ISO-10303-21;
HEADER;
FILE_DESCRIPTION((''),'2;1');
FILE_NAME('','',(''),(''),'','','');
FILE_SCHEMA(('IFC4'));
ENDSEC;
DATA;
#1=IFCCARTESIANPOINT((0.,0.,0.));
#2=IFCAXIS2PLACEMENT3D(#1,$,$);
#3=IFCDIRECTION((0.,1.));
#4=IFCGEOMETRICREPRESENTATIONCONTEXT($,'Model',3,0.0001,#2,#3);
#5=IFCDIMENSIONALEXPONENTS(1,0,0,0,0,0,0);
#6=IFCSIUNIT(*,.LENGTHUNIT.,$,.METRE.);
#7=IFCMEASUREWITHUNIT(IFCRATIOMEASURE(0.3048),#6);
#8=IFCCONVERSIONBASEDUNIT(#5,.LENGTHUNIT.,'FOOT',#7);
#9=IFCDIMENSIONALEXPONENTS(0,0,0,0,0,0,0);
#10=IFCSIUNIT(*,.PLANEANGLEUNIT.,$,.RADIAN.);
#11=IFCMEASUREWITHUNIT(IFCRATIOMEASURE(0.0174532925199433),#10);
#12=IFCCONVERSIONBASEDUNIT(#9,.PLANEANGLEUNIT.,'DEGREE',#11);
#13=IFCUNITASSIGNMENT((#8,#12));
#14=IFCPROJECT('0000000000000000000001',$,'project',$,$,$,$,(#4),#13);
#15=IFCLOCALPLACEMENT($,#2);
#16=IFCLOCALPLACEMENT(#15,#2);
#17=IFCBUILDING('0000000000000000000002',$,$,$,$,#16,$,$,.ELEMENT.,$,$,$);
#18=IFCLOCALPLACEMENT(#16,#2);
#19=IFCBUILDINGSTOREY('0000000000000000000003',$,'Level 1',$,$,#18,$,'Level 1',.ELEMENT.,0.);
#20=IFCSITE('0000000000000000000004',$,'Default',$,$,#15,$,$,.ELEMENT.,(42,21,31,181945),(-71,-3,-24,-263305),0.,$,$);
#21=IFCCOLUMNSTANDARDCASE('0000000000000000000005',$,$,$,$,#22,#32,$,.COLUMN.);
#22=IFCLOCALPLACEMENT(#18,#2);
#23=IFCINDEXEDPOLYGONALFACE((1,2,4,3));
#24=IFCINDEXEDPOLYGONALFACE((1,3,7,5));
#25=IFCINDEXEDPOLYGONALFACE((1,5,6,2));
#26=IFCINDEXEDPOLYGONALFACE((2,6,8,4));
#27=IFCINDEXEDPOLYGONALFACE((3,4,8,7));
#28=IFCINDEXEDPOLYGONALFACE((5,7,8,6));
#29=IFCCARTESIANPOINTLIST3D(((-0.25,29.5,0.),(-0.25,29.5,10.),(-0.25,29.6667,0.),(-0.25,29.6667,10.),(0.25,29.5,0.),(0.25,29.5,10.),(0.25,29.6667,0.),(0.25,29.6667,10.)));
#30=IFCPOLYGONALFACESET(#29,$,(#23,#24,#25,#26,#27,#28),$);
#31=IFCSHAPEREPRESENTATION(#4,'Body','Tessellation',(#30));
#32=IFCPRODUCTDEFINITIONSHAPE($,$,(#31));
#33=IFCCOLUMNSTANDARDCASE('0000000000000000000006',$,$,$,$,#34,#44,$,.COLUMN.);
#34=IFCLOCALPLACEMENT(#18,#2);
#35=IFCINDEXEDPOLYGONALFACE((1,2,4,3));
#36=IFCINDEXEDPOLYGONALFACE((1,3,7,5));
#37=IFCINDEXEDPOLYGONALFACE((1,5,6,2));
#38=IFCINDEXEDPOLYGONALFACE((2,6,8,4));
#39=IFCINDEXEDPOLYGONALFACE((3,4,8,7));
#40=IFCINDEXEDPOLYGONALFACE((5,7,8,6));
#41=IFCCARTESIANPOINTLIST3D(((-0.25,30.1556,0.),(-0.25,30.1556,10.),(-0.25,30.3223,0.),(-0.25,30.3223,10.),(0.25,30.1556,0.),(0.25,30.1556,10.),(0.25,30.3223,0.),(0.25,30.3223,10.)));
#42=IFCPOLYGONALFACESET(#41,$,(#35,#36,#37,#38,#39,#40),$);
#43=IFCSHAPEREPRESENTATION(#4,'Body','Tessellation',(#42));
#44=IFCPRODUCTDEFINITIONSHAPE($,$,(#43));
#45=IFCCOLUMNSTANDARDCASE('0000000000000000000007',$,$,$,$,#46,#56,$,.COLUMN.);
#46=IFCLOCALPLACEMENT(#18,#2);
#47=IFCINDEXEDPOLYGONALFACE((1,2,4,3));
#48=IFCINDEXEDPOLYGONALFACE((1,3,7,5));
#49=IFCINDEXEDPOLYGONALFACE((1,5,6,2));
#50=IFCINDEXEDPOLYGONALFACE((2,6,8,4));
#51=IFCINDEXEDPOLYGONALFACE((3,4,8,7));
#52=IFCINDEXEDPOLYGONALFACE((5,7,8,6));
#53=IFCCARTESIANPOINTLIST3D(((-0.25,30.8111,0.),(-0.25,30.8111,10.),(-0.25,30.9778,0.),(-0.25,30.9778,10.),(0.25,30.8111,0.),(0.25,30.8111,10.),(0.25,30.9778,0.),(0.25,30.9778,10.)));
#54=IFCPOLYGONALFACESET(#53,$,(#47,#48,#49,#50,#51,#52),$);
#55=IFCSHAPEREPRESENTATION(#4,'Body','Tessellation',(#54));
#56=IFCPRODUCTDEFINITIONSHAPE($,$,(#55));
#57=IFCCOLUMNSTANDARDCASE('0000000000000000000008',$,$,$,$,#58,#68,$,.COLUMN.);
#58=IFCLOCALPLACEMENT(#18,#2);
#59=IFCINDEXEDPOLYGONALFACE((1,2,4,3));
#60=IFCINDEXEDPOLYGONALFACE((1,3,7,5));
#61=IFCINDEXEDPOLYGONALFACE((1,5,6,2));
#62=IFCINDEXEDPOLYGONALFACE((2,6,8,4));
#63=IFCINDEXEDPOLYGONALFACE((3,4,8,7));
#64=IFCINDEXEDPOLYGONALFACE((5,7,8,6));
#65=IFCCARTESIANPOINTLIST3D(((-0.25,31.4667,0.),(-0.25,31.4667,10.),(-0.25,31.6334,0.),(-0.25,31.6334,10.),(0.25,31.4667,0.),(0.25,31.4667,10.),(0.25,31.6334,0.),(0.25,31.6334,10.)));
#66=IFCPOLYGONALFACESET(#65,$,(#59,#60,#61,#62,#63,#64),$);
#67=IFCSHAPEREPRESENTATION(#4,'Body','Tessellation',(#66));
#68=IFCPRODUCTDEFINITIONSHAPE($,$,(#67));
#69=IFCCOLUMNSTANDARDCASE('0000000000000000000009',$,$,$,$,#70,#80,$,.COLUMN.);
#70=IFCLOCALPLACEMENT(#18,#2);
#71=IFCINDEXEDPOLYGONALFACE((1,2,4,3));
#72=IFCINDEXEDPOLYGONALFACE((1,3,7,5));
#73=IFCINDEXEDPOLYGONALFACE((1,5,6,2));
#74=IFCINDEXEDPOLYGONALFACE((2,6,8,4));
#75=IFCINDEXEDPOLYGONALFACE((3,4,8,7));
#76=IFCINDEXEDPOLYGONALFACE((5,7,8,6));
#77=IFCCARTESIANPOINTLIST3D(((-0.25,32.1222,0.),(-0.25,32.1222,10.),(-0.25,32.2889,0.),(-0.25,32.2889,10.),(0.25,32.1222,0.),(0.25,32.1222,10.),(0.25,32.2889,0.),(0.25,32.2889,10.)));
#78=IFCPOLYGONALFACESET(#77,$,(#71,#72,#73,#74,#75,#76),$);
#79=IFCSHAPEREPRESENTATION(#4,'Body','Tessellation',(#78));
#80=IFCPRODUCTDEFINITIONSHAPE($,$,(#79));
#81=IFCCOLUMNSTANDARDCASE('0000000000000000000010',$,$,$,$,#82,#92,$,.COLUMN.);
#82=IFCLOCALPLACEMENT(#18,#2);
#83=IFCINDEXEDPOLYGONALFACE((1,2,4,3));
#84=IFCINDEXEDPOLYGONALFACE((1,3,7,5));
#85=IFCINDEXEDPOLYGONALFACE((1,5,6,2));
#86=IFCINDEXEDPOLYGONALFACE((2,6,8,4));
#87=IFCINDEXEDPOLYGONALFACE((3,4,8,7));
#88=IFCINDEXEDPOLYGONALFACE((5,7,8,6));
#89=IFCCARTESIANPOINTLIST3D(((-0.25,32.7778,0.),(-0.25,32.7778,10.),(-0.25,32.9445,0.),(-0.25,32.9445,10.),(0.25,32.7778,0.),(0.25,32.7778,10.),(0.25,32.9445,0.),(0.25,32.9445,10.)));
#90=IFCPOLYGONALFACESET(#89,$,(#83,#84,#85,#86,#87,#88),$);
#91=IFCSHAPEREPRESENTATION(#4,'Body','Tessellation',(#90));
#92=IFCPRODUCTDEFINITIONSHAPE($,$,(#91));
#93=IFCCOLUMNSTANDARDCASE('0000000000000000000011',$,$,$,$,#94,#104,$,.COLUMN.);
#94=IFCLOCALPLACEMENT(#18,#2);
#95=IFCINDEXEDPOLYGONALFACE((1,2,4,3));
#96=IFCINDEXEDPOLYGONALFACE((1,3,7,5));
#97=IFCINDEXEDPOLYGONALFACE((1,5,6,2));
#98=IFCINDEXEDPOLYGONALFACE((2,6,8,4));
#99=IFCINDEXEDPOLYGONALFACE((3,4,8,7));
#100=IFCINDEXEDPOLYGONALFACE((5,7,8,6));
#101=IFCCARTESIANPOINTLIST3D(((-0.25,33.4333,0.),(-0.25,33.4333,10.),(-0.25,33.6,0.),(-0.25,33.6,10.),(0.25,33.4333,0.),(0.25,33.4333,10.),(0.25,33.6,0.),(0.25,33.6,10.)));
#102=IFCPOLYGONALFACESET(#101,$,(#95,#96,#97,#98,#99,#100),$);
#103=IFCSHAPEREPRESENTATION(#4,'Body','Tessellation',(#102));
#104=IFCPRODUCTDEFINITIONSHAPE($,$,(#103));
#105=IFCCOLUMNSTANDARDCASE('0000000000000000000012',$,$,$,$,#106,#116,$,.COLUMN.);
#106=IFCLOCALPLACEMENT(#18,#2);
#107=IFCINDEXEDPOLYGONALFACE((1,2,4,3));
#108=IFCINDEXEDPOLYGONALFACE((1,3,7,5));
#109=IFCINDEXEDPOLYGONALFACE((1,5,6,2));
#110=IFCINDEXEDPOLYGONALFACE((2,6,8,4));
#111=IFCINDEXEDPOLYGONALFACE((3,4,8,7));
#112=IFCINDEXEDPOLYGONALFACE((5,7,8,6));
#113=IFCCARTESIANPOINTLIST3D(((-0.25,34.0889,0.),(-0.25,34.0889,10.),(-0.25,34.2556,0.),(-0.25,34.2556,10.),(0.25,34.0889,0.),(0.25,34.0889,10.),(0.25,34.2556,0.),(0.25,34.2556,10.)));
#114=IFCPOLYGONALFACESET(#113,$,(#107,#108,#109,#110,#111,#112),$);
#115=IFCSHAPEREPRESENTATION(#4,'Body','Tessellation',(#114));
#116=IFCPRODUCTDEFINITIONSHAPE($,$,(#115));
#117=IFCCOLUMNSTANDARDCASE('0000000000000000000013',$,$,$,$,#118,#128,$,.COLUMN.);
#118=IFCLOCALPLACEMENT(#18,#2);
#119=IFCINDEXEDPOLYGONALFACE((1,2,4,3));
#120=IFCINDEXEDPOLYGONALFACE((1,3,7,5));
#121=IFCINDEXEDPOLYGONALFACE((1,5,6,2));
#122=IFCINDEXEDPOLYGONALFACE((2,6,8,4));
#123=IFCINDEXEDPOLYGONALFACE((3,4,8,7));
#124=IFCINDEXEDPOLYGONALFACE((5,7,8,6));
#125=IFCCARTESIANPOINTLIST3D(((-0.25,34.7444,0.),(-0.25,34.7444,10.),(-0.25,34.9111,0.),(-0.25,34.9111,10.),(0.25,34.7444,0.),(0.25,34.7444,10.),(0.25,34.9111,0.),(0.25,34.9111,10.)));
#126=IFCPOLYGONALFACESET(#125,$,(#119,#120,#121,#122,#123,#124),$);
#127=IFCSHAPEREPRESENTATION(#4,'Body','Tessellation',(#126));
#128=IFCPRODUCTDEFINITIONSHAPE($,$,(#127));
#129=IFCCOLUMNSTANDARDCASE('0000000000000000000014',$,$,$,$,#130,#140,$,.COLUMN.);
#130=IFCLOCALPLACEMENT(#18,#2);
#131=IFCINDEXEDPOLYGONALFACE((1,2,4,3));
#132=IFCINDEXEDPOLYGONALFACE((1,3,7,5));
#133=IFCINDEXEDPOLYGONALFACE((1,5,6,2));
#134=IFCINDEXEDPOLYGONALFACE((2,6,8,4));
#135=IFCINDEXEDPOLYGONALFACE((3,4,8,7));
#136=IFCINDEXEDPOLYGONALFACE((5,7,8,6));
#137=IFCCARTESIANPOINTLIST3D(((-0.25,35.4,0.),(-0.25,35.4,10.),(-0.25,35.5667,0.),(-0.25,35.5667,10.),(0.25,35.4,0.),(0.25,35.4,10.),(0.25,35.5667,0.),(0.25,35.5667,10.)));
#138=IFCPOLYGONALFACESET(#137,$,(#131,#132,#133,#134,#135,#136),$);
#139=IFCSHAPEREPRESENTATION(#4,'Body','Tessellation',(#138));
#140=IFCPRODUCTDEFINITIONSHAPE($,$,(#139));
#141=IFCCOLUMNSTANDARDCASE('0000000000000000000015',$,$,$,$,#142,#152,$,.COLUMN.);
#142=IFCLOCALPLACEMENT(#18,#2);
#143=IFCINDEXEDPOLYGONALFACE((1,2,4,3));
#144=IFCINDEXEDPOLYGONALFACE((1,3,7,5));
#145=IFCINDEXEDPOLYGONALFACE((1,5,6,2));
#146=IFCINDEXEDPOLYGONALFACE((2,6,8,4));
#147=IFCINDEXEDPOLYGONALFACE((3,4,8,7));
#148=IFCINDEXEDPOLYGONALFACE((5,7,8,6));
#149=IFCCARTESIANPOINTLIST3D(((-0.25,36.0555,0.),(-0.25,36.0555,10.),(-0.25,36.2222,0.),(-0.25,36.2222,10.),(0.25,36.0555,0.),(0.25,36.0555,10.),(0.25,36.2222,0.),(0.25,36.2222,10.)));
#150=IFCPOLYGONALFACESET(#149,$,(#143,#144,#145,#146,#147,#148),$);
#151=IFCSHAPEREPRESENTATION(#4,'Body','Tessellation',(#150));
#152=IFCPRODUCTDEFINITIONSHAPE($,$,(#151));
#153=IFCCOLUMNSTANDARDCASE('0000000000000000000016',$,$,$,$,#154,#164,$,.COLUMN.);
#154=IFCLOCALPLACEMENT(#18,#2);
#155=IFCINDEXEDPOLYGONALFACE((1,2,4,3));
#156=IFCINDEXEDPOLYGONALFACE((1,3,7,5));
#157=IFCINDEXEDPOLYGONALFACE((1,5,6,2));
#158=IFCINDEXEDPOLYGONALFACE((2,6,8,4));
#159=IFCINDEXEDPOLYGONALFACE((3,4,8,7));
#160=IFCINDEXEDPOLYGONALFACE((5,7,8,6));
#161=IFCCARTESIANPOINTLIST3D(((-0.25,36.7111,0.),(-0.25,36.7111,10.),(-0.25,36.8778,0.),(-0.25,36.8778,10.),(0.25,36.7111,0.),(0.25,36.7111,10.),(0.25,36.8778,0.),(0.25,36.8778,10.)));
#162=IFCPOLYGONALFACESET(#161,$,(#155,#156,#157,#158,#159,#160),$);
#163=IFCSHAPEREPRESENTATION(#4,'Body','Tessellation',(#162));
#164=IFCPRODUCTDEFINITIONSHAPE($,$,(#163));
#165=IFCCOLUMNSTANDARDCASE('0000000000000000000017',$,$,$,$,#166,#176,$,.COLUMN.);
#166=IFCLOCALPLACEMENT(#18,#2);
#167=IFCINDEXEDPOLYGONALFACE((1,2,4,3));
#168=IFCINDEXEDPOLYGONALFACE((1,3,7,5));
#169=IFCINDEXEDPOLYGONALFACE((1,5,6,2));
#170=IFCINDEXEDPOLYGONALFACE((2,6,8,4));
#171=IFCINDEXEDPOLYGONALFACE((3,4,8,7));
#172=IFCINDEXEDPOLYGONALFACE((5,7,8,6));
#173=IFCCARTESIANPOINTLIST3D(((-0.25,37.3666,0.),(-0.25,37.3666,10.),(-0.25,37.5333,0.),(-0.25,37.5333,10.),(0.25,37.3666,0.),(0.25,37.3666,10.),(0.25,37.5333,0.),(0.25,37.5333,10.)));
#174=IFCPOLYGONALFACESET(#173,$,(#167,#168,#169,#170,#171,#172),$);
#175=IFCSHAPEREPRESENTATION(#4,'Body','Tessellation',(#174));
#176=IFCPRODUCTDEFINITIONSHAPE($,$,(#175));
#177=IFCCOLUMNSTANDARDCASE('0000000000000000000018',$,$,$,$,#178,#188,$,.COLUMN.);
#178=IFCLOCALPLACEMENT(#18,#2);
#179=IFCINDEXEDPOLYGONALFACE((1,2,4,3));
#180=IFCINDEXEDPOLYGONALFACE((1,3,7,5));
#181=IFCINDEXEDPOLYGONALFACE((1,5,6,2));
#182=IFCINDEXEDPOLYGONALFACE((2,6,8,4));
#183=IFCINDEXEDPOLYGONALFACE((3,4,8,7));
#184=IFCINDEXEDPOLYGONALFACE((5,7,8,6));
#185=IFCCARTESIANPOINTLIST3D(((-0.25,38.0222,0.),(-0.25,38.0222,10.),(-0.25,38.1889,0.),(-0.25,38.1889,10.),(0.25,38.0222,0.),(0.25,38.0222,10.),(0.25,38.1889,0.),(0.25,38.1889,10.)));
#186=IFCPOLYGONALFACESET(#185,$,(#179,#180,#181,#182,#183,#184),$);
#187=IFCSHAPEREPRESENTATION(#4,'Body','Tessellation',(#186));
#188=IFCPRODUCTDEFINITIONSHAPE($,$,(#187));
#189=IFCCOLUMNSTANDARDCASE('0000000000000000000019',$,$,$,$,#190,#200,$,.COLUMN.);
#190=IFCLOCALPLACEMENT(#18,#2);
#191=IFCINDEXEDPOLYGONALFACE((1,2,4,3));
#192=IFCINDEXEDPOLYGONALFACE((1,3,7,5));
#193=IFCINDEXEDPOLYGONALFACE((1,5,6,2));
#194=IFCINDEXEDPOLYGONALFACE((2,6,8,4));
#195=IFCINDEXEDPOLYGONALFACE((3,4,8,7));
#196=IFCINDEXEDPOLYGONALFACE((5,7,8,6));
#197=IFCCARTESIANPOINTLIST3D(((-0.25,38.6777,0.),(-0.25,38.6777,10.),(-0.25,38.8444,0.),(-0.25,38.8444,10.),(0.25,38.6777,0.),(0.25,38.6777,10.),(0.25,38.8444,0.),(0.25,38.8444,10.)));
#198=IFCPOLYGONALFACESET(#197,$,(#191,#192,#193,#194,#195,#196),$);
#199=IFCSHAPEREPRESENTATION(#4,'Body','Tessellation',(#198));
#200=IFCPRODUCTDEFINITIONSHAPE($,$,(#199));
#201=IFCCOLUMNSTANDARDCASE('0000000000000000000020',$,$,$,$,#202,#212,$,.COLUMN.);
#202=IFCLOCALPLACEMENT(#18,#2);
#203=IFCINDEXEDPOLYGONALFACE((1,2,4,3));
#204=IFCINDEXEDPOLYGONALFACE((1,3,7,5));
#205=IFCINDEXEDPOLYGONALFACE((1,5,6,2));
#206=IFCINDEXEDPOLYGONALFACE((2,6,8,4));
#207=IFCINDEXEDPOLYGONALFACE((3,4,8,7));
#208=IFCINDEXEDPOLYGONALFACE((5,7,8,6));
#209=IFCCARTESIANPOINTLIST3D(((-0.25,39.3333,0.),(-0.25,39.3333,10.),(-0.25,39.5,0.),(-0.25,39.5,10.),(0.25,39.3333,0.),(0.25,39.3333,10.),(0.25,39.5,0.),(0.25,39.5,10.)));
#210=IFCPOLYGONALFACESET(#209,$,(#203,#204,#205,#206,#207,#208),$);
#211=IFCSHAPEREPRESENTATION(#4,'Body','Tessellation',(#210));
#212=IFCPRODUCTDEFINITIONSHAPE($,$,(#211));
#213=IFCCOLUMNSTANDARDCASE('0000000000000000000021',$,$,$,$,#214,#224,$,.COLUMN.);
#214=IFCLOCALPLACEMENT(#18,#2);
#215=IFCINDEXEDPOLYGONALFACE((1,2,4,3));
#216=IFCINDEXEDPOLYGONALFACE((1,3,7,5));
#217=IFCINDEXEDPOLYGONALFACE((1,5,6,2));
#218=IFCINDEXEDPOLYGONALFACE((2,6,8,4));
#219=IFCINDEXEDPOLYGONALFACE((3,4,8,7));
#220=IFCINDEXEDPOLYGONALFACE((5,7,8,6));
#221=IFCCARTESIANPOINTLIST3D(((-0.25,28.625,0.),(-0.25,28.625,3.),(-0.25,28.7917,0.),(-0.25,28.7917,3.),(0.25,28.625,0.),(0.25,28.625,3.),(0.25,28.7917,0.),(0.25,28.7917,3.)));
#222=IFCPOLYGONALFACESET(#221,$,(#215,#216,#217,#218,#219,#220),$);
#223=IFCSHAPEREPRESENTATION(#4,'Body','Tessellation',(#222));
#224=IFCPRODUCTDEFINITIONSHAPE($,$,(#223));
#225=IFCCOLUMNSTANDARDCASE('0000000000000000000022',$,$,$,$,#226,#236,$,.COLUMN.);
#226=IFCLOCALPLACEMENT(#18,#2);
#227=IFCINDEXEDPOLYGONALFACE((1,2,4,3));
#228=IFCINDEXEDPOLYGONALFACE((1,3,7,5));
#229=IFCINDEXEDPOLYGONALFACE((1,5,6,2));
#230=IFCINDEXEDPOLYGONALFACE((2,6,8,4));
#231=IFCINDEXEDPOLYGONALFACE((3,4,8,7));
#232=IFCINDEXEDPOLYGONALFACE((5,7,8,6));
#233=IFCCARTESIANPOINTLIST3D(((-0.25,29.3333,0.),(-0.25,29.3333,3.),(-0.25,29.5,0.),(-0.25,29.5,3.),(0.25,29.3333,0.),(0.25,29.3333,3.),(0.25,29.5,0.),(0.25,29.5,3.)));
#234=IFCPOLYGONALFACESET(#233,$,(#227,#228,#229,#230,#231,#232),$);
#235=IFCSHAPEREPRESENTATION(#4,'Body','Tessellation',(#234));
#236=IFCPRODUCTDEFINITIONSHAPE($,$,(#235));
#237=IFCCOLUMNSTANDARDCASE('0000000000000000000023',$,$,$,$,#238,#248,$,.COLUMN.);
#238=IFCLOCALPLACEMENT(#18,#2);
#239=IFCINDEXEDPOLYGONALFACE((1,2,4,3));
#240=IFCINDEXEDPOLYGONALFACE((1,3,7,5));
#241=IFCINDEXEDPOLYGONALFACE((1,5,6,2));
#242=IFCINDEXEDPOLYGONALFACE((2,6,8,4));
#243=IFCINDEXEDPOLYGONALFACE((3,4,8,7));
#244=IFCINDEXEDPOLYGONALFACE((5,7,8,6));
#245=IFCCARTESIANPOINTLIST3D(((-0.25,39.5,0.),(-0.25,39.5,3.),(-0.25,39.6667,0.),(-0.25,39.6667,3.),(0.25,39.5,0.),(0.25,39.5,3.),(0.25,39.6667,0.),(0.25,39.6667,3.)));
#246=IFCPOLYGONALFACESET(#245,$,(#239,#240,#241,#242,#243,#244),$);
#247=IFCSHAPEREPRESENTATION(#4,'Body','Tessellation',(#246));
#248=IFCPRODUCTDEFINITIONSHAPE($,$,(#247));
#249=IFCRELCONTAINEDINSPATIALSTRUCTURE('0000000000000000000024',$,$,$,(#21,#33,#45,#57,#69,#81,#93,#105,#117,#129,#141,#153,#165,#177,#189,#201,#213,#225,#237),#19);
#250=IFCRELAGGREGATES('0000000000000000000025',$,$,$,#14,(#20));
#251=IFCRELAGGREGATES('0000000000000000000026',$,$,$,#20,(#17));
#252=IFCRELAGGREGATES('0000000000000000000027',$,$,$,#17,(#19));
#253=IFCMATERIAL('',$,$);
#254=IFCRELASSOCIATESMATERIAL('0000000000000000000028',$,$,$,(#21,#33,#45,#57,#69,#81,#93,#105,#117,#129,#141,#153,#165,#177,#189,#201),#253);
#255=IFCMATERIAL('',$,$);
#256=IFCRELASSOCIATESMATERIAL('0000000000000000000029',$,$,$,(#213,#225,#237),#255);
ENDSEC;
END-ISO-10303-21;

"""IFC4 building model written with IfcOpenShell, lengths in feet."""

from ifc_helpers import new_model, entity, si_unit, converted_unit, direction, frame, origin, place, context, project, spatial, rectangle, extrude, material, element, save


model = new_model("IFC4")

# Units and contexts
model_context = context("Model", 3, precision=0.0001, world=origin(), true_north=direction((0.0, 1.0)))
ifc_project = project(units=[converted_unit("LENGTHUNIT", "FOOT", entity("IfcRatioMeasure", 0.3048), si_unit("LENGTHUNIT", "METRE"), dimensions=[1, 0, 0, 0, 0, 0, 0]), converted_unit("PLANEANGLEUNIT", "DEGREE", entity("IfcRatioMeasure", 0.0174532925199433), si_unit("PLANEANGLEUNIT", "RADIAN"), dimensions=[0, 0, 0, 0, 0, 0, 0])], contexts=[model_context])

# Site, building, storey
site_placement = place(None, origin())
site = spatial("IfcSite", under=ifc_project, at=site_placement, Name="Default", CompositionType="ELEMENT", RefLatitude=(42, 21, 31, 181945), RefLongitude=(-71, -3, -24, -263305), RefElevation=0.0)
building_placement = place(site_placement, origin())
building = spatial("IfcBuilding", under=site, at=building_placement, CompositionType="ELEMENT")
storey_placement = place(building_placement, origin())
storey = spatial("IfcBuildingStorey", under=building, at=storey_placement, Name="Level 1", LongName="Level 1", CompositionType="ELEMENT", Elevation=0.0)

# Columns
ifc_material_1 = material(Name="")
placement = place(storey_placement, frame((0.0, -0.25, 0.0), z_axis=(0.0, 0.0, 1.0), x_axis=(0.0, 1.0, 0.0)))
for number, where, z_axis, x_axis in (
    (1, (29.8334, 0.0, 0.0), (0.0, 0.0, 1.0), (1.0, 0.0, 0.0)),
    (2, (30.4889, 0.0, 0.0), (0.0, 0.0, 1.0), (1.0, 0.0, 0.0)),
    (3, (31.1445, 0.0, 0.0), (0.0, 0.0, 1.0), (1.0, 0.0, 0.0)),
    (4, (31.8, 0.0, 0.0), (0.0, 0.0, 1.0), (1.0, 0.0, 0.0)),
    (5, (32.4556, 0.0, 0.0), (0.0, 0.0, 1.0), (1.0, 0.0, 0.0)),
    (6, (33.1111, 0.0, 0.0), (0.0, 0.0, 1.0), (1.0, 0.0, 0.0)),
    (7, (33.7667, 0.0, 0.0), (0.0, 0.0, 1.0), (1.0, 0.0, 0.0)),
    (8, (34.4222, 0.0, 0.0), (0.0, 0.0, 1.0), (1.0, 0.0, 0.0)),
    (9, (35.0778, 0.0, 0.0), (0.0, 0.0, 1.0), (1.0, 0.0, 0.0)),
    (10, (35.7333, 0.0, 0.0), (0.0, 0.0, 1.0), (1.0, 0.0, 0.0)),
    (11, (36.3889, 0.0, 0.0), (0.0, 0.0, 1.0), (1.0, 0.0, 0.0)),
    (12, (37.0444, 0.0, 0.0), (0.0, 0.0, 1.0), (1.0, 0.0, 0.0)),
    (13, (37.7, 0.0, 0.0), (0.0, 0.0, 1.0), (1.0, 0.0, 0.0)),
    (14, (38.3555, 0.0, 0.0), (0.0, 0.0, 1.0), (1.0, 0.0, 0.0)),
    (15, (39.0111, 0.0, 0.0), (0.0, 0.0, 1.0), (1.0, 0.0, 0.0)),
    (16, (39.6667, 0.0, 0.0), (0.0, 0.0, 1.0), (1.0, 0.0, 0.0)),
):
    element("IfcColumnStandardCase", number, at=place(placement, frame(where, z_axis=z_axis, x_axis=x_axis)), inside=storey, material=ifc_material_1, PredefinedType="COLUMN", context=model_context, shape_type="SweptSolid", body=[
        extrude(rectangle(XDim=0.1667, YDim=0.5), origin(), (0.0, 0.0, 1.0), 10.0),
    ])
ifc_material_2 = material(Name="")
for number, where, z_axis, x_axis in (
    (17, (28.9583, 0.0, 0.0), (0.0, 0.0, 1.0), (1.0, 0.0, 0.0)),
    (18, (29.6667, 0.0, 0.0), (0.0, 0.0, 1.0), (1.0, 0.0, 0.0)),
    (19, (39.8334, 0.0, 0.0), (0.0, 0.0, 1.0), (1.0, 0.0, 0.0)),
):
    element("IfcColumnStandardCase", number, at=place(placement, frame(where, z_axis=z_axis, x_axis=x_axis)), inside=storey, material=ifc_material_2, PredefinedType="COLUMN", context=model_context, shape_type="SweptSolid", body=[
        extrude(rectangle(XDim=0.1667, YDim=0.5), origin(), (0.0, 0.0, 1.0), 3.0),
    ])

save(model, "model.ifc")
